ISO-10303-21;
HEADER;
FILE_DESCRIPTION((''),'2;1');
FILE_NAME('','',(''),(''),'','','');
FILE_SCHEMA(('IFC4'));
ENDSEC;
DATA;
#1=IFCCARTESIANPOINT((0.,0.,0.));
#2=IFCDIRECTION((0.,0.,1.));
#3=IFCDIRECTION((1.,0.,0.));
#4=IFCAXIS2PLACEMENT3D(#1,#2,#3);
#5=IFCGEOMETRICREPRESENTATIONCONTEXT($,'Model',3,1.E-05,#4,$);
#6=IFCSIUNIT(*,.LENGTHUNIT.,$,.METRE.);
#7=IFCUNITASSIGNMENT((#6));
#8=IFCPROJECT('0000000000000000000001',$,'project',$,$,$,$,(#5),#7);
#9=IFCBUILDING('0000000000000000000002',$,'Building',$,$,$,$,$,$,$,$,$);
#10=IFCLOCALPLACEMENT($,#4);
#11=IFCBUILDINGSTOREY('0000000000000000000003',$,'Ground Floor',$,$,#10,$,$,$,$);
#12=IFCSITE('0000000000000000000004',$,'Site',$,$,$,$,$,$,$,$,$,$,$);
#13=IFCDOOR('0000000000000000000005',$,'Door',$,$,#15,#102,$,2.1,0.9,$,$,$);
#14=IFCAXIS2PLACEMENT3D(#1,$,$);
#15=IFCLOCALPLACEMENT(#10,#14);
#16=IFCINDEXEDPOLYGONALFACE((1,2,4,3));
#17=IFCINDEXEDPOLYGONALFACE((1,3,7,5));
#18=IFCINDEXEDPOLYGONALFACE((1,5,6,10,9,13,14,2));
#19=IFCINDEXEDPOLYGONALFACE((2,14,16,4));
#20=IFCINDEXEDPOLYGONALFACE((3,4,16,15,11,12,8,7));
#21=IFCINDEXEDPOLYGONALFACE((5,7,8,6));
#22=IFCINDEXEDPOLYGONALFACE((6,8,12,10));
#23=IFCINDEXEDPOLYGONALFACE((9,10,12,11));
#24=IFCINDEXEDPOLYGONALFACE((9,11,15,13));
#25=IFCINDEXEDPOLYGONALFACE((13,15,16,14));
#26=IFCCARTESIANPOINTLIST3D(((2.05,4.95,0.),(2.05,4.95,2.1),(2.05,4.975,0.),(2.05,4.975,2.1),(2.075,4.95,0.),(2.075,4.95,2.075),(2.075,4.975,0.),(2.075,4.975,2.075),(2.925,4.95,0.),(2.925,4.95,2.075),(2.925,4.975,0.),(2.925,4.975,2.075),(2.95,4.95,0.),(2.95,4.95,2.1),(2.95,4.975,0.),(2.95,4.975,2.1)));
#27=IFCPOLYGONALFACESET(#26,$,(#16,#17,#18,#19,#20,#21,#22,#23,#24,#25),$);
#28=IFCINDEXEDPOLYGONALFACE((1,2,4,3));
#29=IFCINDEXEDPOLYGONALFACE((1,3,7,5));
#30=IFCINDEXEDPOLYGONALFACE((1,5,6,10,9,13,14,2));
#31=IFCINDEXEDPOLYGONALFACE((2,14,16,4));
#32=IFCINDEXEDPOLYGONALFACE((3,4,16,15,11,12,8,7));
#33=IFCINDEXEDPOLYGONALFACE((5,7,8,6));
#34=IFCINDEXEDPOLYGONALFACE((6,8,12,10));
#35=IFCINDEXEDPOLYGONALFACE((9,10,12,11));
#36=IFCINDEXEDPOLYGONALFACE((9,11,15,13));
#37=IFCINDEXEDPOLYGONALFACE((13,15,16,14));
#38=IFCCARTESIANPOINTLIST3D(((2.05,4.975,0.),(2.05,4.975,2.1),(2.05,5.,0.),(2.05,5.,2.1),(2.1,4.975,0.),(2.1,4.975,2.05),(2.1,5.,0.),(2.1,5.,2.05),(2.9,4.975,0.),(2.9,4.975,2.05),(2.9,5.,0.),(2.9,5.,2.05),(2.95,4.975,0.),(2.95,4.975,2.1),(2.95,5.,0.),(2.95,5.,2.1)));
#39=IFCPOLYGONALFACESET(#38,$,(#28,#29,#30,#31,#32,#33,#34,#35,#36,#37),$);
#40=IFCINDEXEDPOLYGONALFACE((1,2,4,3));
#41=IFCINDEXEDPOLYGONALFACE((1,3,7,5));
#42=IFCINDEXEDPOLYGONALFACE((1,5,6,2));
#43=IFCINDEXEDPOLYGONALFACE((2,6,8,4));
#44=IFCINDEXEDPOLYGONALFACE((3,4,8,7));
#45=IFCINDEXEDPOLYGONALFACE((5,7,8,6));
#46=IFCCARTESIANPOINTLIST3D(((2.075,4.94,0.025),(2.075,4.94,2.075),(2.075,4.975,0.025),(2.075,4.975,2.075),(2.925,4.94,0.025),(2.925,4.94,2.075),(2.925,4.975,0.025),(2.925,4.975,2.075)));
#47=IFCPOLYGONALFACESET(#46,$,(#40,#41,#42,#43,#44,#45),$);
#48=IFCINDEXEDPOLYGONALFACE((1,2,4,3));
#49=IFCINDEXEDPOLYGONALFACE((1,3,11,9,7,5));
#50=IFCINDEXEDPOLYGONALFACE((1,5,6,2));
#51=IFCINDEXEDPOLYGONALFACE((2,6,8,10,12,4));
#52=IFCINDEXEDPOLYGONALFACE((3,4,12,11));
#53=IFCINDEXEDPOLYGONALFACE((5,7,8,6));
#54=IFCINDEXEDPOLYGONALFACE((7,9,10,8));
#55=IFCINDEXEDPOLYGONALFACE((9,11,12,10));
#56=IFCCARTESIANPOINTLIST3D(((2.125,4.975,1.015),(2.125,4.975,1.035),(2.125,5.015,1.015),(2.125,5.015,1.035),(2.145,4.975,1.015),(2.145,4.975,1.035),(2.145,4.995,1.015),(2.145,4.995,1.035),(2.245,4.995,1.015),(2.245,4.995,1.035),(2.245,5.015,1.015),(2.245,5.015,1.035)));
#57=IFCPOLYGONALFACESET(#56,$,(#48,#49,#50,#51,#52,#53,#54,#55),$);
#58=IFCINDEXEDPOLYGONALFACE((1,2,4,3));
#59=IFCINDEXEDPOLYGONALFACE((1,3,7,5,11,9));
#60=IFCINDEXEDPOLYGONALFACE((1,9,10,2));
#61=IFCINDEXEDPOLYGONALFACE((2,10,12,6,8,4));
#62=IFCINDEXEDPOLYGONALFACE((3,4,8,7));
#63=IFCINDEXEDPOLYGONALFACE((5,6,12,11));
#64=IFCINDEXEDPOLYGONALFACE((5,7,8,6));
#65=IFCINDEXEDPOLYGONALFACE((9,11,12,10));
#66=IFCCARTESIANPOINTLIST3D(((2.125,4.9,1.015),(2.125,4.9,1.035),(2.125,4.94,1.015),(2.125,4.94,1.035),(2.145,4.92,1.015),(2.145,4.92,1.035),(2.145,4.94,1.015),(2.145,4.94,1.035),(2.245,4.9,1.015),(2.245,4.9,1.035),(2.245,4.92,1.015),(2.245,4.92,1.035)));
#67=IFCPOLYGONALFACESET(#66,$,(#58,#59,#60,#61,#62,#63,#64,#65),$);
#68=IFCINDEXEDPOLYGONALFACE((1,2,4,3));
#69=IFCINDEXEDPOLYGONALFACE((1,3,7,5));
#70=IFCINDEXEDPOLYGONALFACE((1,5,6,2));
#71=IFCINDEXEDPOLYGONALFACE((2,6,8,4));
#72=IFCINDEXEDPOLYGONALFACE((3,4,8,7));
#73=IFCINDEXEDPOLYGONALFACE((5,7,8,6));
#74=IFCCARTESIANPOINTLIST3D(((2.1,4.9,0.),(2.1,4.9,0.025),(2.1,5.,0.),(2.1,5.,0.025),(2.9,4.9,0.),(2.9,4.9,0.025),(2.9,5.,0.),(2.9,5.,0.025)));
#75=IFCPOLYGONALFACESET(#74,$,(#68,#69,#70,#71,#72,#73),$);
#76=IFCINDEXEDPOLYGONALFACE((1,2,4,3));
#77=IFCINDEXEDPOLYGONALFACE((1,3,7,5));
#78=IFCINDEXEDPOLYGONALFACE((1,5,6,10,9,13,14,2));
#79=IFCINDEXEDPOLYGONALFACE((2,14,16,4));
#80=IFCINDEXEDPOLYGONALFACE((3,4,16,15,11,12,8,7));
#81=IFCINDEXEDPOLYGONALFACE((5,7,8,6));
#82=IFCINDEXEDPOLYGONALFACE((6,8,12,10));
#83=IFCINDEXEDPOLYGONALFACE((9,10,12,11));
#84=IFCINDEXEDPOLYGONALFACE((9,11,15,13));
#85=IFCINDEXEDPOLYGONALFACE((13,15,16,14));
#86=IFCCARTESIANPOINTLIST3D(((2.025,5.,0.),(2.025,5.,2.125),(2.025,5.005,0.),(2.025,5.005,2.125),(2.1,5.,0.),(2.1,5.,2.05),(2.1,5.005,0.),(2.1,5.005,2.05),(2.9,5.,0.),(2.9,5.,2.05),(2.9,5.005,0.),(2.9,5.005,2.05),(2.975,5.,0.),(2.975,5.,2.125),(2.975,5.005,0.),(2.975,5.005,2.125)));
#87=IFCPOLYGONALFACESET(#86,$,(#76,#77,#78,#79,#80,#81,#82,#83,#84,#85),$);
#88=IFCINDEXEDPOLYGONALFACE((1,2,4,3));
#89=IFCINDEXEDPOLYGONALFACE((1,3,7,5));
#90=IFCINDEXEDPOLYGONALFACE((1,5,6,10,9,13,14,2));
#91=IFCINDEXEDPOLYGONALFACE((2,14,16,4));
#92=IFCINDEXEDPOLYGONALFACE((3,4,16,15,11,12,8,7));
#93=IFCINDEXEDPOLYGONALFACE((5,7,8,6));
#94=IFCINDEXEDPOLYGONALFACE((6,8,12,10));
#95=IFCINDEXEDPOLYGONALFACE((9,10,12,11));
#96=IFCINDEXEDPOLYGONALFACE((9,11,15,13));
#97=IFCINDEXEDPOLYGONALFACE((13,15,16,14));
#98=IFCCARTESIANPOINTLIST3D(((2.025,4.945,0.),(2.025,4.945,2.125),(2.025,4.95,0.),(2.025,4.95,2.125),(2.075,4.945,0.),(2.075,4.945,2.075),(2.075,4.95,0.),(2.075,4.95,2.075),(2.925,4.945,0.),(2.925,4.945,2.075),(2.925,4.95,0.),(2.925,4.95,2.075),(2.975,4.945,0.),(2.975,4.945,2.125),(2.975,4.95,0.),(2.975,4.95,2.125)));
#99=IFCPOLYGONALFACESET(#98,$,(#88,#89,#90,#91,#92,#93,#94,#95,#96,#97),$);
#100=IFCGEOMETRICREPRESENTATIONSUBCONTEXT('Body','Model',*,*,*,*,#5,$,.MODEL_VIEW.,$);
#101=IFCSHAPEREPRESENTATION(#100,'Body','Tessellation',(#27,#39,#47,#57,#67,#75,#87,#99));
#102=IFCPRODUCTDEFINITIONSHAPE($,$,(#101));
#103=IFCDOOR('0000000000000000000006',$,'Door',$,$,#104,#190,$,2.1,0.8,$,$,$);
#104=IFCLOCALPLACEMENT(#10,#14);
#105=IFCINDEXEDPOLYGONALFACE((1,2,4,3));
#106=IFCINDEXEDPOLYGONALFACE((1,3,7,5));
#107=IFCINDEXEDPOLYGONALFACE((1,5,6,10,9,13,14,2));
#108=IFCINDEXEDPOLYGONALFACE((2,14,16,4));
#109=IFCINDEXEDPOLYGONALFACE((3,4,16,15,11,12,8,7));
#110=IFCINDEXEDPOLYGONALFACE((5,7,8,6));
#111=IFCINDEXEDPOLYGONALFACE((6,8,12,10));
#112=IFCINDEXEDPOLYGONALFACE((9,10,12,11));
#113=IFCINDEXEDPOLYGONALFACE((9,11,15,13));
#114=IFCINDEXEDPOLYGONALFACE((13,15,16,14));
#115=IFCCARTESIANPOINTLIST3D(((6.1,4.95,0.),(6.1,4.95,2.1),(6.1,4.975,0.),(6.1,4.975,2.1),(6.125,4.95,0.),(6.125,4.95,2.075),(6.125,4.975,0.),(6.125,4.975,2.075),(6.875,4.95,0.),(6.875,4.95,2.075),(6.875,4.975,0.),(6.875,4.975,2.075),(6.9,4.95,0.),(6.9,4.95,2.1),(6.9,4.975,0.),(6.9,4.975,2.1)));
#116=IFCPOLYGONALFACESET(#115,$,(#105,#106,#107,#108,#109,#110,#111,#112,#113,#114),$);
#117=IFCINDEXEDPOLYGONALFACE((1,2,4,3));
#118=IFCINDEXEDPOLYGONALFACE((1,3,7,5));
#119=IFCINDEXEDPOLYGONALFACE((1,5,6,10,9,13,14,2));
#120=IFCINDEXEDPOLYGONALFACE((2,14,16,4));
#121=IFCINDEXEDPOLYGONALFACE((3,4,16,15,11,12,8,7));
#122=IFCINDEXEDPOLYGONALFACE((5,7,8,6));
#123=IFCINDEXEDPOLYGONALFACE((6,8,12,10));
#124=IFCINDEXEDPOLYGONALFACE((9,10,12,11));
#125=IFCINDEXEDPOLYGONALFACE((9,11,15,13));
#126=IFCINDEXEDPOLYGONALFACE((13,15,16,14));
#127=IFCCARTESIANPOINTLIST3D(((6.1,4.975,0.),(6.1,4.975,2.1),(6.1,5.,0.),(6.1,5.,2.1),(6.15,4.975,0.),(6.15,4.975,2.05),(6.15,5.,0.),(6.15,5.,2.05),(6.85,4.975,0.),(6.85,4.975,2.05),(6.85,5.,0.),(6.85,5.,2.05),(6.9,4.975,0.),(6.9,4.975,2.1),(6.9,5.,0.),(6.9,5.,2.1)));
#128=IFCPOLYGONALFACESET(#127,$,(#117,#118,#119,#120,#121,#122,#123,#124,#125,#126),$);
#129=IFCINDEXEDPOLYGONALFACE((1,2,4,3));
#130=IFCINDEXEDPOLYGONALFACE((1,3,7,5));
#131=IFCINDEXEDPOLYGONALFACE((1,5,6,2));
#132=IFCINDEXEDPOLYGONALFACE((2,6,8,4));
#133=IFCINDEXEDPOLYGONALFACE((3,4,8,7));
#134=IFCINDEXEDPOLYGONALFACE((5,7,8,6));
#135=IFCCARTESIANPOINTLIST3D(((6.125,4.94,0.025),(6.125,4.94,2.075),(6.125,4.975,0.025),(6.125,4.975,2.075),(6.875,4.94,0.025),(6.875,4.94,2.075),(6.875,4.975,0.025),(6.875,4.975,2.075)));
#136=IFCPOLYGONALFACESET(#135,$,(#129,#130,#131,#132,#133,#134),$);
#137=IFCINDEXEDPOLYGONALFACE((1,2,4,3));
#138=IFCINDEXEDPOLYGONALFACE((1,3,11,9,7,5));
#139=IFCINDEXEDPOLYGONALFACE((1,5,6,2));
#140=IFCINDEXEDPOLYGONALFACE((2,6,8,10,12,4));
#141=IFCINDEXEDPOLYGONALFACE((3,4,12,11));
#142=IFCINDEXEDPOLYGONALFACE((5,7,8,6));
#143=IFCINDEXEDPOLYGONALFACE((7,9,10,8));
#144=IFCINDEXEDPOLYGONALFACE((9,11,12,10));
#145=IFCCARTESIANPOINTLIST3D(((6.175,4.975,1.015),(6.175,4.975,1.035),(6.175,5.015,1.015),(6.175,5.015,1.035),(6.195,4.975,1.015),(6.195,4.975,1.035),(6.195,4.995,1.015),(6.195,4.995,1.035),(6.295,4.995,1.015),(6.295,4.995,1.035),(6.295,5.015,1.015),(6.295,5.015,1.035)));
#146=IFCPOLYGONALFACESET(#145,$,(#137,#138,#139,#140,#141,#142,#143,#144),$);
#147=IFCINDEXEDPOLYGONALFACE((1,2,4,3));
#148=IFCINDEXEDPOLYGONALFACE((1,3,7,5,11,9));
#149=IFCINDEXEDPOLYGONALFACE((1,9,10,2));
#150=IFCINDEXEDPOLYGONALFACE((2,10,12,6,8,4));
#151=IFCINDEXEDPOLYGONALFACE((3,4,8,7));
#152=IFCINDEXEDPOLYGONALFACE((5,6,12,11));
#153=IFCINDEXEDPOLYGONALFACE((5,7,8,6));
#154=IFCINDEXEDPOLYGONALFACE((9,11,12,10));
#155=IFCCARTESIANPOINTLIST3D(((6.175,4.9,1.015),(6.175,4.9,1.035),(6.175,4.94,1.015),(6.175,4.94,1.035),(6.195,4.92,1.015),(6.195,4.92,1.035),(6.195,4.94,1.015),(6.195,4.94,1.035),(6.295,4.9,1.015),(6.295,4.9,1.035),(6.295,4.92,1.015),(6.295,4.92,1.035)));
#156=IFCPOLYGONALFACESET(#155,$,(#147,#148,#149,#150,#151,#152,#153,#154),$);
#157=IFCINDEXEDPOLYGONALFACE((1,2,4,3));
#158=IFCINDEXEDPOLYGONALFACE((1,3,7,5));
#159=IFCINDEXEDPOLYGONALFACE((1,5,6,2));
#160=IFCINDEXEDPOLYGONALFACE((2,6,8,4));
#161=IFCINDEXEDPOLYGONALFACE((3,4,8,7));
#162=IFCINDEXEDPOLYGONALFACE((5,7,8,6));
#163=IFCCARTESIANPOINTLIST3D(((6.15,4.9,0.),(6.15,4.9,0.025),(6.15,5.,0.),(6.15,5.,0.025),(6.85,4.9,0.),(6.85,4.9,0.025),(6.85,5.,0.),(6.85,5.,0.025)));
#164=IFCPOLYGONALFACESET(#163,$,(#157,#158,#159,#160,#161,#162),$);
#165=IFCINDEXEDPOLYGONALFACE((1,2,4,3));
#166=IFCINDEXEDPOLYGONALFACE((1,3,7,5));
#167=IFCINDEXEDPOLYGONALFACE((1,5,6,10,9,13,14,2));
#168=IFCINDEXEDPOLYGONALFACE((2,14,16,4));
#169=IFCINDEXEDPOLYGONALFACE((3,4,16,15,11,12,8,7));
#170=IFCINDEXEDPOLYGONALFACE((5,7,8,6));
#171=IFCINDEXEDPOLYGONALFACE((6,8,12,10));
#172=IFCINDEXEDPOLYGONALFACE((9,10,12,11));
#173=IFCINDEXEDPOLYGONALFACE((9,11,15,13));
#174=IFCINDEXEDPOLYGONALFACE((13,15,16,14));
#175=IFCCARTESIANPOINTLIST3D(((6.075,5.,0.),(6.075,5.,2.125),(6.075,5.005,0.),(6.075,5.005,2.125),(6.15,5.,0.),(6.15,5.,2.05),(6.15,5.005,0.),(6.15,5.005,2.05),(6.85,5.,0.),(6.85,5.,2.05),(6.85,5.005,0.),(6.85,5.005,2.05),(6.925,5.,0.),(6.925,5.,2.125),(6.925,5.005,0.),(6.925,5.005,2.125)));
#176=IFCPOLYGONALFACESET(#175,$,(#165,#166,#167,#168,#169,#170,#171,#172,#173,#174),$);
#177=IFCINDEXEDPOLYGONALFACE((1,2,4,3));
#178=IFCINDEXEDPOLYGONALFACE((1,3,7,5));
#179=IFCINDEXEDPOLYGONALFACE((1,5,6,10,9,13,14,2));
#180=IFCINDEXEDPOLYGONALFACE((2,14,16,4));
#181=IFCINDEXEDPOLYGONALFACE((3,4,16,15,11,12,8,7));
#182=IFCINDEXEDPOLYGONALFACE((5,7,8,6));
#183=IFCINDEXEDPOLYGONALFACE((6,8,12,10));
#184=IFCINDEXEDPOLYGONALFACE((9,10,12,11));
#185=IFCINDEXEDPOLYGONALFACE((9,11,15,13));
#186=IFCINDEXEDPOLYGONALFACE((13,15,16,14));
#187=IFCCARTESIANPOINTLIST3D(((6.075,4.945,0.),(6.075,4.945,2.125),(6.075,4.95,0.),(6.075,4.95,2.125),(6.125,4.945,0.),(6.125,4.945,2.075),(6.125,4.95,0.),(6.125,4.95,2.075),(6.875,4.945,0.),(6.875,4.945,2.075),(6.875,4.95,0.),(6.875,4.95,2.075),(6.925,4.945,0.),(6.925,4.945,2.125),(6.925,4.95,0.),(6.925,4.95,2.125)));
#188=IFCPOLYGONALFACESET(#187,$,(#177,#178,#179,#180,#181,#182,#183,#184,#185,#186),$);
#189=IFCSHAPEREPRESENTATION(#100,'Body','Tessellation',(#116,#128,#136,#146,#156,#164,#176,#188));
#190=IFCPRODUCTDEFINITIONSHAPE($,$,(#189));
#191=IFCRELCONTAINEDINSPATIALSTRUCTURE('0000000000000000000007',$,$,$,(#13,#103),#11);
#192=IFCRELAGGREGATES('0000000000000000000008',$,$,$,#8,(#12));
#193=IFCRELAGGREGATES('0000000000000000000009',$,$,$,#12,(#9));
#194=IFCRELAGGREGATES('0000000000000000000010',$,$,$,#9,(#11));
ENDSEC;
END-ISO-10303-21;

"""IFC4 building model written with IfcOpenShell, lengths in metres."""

from ifc_helpers import new_model, si_unit, frame, origin_with_axes, place, context, subcontext, project, spatial, line, indexed_curve, outline, extrude, element, save


model = new_model("IFC4")

# Units and contexts
model_context = context("Model", 3, precision=1e-05, world=origin_with_axes())
body_context = subcontext(model_context, "Body", "Model", "MODEL_VIEW")
ifc_project = project(units=[si_unit("LENGTHUNIT", "METRE")], contexts=[model_context])

# Site, building, storey
site = spatial("IfcSite", under=ifc_project, Name="Site")
building = spatial("IfcBuilding", under=site, Name="Building")
storey_placement = place(None, origin_with_axes())
storey = spatial("IfcBuildingStorey", under=building, at=storey_placement, Name="Ground Floor")

# Doors
door_1_placement = place(storey_placement, frame((2.95, 5.0, 0.0), z_axis=(0.0, 0.0, 1.0), x_axis=(-1.0, 0.0, 0.0)))
element("IfcDoor", 1, at=door_1_placement, inside=storey, Name="Door", OverallHeight=2.1, OverallWidth=0.9, context=body_context, shape_type="SweptSolid", body=[
    extrude(outline(indexed_curve([(0.0, 0.0), (0.0, 2.1), (0.9, 2.1), (0.9, 0.0), (0.875, 0.0), (0.875, 2.075), (0.025, 2.075), (0.025, 0.0)], segments=[line(1, 2, 3, 4, 5, 6, 7, 8, 1)])), frame((0.0, 0.025, 0.0), z_axis=(0.0, -1.0, 0.0), x_axis=(1.0, 0.0, 0.0)), (0.0, 0.0, -1.0), 0.025),
    extrude(outline(indexed_curve([(0.0, 0.0), (0.0, 2.1), (0.9, 2.1), (0.9, 0.0), (0.85, 0.0), (0.85, 2.05), (0.05, 2.05), (0.05, 0.0)], segments=[line(1, 2, 3, 4, 5, 6, 7, 8, 1)])), frame((0.0, 0.0, 0.0), z_axis=(0.0, -1.0, 0.0), x_axis=(1.0, 0.0, 0.0)), (0.0, 0.0, -1.0), 0.025),
    extrude(outline(indexed_curve([(0.0, 0.0), (0.85, 0.0), (0.85, 0.035), (0.0, 0.035)], segments=[line(1, 2, 3, 4, 1)])), frame((0.025, 0.025, 0.025), z_axis=(0.0, 0.0, 1.0), x_axis=(1.0, 0.0, 0.0)), (0.0, 0.0, 1.0), 2.05),
    extrude(outline(indexed_curve([(0.0, 0.0), (0.0, -0.04), (-0.12, -0.04), (-0.12, -0.02), (-0.02, -0.02), (-0.02, 0.0)], segments=[line(1, 2, 3, 4, 5, 6, 1)])), frame((0.825, 0.025, 1.015), z_axis=(0.0, 0.0, 1.0), x_axis=(1.0, 0.0, 0.0)), (0.0, 0.0, 1.0), 0.02),
    extrude(outline(indexed_curve([(0.0, 0.0), (0.0, 0.04), (-0.12, 0.04), (-0.12, 0.02), (-0.02, 0.02), (-0.02, 0.0)], segments=[line(1, 2, 3, 4, 5, 6, 1)])), frame((0.825, 0.06, 1.015), z_axis=(0.0, 0.0, 1.0), x_axis=(1.0, 0.0, 0.0)), (0.0, 0.0, 1.0), 0.02),
    extrude(outline(indexed_curve([(0.0, 0.0), (0.8, 0.0), (0.8, 0.1), (0.0, 0.1)], segments=[line(1, 2, 3, 4, 1)])), frame((0.05, 0.0, 0.0), z_axis=(0.0, 0.0, 1.0), x_axis=(1.0, 0.0, 0.0)), (0.0, 0.0, 1.0), 0.025),
    extrude(outline(indexed_curve([(0.0, 0.0), (0.0, 2.125), (0.95, 2.125), (0.95, 0.0), (0.875, 0.0), (0.875, 2.05), (0.075, 2.05), (0.075, 0.0)], segments=[line(1, 2, 3, 4, 5, 6, 7, 8, 1)])), frame((-0.025, -0.005, 0.0), z_axis=(0.0, -1.0, 0.0), x_axis=(1.0, 0.0, 0.0)), (0.0, 0.0, -1.0), 0.005),
    extrude(outline(indexed_curve([(0.0, 0.0), (0.0, 2.125), (0.95, 2.125), (0.95, 0.0), (0.9, 0.0), (0.9, 2.075), (0.05, 2.075), (0.05, 0.0)], segments=[line(1, 2, 3, 4, 5, 6, 7, 8, 1)])), frame((-0.025, 0.05, 0.0), z_axis=(0.0, -1.0, 0.0), x_axis=(1.0, 0.0, 0.0)), (0.0, 0.0, -1.0), 0.005),
])
door_2_placement = place(storey_placement, frame((6.9, 5.0, 0.0), z_axis=(0.0, 0.0, 1.0), x_axis=(-1.0, 0.0, 0.0)))
element("IfcDoor", 2, at=door_2_placement, inside=storey, Name="Door", OverallHeight=2.1, OverallWidth=0.8, context=body_context, shape_type="SweptSolid", body=[
    extrude(outline(indexed_curve([(0.0, 0.0), (0.0, 2.1), (0.8, 2.1), (0.8, 0.0), (0.775, 0.0), (0.775, 2.075), (0.025, 2.075), (0.025, 0.0)], segments=[line(1, 2, 3, 4, 5, 6, 7, 8, 1)])), frame((0.0, 0.025, 0.0), z_axis=(0.0, -1.0, 0.0), x_axis=(1.0, 0.0, 0.0)), (0.0, 0.0, -1.0), 0.025),
    extrude(outline(indexed_curve([(0.0, 0.0), (0.0, 2.1), (0.8, 2.1), (0.8, 0.0), (0.75, 0.0), (0.75, 2.05), (0.05, 2.05), (0.05, 0.0)], segments=[line(1, 2, 3, 4, 5, 6, 7, 8, 1)])), frame((0.0, 0.0, 0.0), z_axis=(0.0, -1.0, 0.0), x_axis=(1.0, 0.0, 0.0)), (0.0, 0.0, -1.0), 0.025),
    extrude(outline(indexed_curve([(0.0, 0.0), (0.75, 0.0), (0.75, 0.035), (0.0, 0.035)], segments=[line(1, 2, 3, 4, 1)])), frame((0.025, 0.025, 0.025), z_axis=(0.0, 0.0, 1.0), x_axis=(1.0, 0.0, 0.0)), (0.0, 0.0, 1.0), 2.05),
    extrude(outline(indexed_curve([(0.0, 0.0), (0.0, -0.04), (-0.12, -0.04), (-0.12, -0.02), (-0.02, -0.02), (-0.02, 0.0)], segments=[line(1, 2, 3, 4, 5, 6, 1)])), frame((0.725, 0.025, 1.015), z_axis=(0.0, 0.0, 1.0), x_axis=(1.0, 0.0, 0.0)), (0.0, 0.0, 1.0), 0.02),
    extrude(outline(indexed_curve([(0.0, 0.0), (0.0, 0.04), (-0.12, 0.04), (-0.12, 0.02), (-0.02, 0.02), (-0.02, 0.0)], segments=[line(1, 2, 3, 4, 5, 6, 1)])), frame((0.725, 0.06, 1.015), z_axis=(0.0, 0.0, 1.0), x_axis=(1.0, 0.0, 0.0)), (0.0, 0.0, 1.0), 0.02),
    extrude(outline(indexed_curve([(0.0, 0.0), (0.7, 0.0), (0.7, 0.1), (0.0, 0.1)], segments=[line(1, 2, 3, 4, 1)])), frame((0.05, 0.0, 0.0), z_axis=(0.0, 0.0, 1.0), x_axis=(1.0, 0.0, 0.0)), (0.0, 0.0, 1.0), 0.025),
    extrude(outline(indexed_curve([(0.0, 0.0), (0.0, 2.125), (0.85, 2.125), (0.85, 0.0), (0.775, 0.0), (0.775, 2.05), (0.075, 2.05), (0.075, 0.0)], segments=[line(1, 2, 3, 4, 5, 6, 7, 8, 1)])), frame((-0.025, -0.005, 0.0), z_axis=(0.0, -1.0, 0.0), x_axis=(1.0, 0.0, 0.0)), (0.0, 0.0, -1.0), 0.005),
    extrude(outline(indexed_curve([(0.0, 0.0), (0.0, 2.125), (0.85, 2.125), (0.85, 0.0), (0.8, 0.0), (0.8, 2.075), (0.05, 2.075), (0.05, 0.0)], segments=[line(1, 2, 3, 4, 5, 6, 7, 8, 1)])), frame((-0.025, 0.05, 0.0), z_axis=(0.0, -1.0, 0.0), x_axis=(1.0, 0.0, 0.0)), (0.0, 0.0, -1.0), 0.005),
])

save(model, "model.ifc")
